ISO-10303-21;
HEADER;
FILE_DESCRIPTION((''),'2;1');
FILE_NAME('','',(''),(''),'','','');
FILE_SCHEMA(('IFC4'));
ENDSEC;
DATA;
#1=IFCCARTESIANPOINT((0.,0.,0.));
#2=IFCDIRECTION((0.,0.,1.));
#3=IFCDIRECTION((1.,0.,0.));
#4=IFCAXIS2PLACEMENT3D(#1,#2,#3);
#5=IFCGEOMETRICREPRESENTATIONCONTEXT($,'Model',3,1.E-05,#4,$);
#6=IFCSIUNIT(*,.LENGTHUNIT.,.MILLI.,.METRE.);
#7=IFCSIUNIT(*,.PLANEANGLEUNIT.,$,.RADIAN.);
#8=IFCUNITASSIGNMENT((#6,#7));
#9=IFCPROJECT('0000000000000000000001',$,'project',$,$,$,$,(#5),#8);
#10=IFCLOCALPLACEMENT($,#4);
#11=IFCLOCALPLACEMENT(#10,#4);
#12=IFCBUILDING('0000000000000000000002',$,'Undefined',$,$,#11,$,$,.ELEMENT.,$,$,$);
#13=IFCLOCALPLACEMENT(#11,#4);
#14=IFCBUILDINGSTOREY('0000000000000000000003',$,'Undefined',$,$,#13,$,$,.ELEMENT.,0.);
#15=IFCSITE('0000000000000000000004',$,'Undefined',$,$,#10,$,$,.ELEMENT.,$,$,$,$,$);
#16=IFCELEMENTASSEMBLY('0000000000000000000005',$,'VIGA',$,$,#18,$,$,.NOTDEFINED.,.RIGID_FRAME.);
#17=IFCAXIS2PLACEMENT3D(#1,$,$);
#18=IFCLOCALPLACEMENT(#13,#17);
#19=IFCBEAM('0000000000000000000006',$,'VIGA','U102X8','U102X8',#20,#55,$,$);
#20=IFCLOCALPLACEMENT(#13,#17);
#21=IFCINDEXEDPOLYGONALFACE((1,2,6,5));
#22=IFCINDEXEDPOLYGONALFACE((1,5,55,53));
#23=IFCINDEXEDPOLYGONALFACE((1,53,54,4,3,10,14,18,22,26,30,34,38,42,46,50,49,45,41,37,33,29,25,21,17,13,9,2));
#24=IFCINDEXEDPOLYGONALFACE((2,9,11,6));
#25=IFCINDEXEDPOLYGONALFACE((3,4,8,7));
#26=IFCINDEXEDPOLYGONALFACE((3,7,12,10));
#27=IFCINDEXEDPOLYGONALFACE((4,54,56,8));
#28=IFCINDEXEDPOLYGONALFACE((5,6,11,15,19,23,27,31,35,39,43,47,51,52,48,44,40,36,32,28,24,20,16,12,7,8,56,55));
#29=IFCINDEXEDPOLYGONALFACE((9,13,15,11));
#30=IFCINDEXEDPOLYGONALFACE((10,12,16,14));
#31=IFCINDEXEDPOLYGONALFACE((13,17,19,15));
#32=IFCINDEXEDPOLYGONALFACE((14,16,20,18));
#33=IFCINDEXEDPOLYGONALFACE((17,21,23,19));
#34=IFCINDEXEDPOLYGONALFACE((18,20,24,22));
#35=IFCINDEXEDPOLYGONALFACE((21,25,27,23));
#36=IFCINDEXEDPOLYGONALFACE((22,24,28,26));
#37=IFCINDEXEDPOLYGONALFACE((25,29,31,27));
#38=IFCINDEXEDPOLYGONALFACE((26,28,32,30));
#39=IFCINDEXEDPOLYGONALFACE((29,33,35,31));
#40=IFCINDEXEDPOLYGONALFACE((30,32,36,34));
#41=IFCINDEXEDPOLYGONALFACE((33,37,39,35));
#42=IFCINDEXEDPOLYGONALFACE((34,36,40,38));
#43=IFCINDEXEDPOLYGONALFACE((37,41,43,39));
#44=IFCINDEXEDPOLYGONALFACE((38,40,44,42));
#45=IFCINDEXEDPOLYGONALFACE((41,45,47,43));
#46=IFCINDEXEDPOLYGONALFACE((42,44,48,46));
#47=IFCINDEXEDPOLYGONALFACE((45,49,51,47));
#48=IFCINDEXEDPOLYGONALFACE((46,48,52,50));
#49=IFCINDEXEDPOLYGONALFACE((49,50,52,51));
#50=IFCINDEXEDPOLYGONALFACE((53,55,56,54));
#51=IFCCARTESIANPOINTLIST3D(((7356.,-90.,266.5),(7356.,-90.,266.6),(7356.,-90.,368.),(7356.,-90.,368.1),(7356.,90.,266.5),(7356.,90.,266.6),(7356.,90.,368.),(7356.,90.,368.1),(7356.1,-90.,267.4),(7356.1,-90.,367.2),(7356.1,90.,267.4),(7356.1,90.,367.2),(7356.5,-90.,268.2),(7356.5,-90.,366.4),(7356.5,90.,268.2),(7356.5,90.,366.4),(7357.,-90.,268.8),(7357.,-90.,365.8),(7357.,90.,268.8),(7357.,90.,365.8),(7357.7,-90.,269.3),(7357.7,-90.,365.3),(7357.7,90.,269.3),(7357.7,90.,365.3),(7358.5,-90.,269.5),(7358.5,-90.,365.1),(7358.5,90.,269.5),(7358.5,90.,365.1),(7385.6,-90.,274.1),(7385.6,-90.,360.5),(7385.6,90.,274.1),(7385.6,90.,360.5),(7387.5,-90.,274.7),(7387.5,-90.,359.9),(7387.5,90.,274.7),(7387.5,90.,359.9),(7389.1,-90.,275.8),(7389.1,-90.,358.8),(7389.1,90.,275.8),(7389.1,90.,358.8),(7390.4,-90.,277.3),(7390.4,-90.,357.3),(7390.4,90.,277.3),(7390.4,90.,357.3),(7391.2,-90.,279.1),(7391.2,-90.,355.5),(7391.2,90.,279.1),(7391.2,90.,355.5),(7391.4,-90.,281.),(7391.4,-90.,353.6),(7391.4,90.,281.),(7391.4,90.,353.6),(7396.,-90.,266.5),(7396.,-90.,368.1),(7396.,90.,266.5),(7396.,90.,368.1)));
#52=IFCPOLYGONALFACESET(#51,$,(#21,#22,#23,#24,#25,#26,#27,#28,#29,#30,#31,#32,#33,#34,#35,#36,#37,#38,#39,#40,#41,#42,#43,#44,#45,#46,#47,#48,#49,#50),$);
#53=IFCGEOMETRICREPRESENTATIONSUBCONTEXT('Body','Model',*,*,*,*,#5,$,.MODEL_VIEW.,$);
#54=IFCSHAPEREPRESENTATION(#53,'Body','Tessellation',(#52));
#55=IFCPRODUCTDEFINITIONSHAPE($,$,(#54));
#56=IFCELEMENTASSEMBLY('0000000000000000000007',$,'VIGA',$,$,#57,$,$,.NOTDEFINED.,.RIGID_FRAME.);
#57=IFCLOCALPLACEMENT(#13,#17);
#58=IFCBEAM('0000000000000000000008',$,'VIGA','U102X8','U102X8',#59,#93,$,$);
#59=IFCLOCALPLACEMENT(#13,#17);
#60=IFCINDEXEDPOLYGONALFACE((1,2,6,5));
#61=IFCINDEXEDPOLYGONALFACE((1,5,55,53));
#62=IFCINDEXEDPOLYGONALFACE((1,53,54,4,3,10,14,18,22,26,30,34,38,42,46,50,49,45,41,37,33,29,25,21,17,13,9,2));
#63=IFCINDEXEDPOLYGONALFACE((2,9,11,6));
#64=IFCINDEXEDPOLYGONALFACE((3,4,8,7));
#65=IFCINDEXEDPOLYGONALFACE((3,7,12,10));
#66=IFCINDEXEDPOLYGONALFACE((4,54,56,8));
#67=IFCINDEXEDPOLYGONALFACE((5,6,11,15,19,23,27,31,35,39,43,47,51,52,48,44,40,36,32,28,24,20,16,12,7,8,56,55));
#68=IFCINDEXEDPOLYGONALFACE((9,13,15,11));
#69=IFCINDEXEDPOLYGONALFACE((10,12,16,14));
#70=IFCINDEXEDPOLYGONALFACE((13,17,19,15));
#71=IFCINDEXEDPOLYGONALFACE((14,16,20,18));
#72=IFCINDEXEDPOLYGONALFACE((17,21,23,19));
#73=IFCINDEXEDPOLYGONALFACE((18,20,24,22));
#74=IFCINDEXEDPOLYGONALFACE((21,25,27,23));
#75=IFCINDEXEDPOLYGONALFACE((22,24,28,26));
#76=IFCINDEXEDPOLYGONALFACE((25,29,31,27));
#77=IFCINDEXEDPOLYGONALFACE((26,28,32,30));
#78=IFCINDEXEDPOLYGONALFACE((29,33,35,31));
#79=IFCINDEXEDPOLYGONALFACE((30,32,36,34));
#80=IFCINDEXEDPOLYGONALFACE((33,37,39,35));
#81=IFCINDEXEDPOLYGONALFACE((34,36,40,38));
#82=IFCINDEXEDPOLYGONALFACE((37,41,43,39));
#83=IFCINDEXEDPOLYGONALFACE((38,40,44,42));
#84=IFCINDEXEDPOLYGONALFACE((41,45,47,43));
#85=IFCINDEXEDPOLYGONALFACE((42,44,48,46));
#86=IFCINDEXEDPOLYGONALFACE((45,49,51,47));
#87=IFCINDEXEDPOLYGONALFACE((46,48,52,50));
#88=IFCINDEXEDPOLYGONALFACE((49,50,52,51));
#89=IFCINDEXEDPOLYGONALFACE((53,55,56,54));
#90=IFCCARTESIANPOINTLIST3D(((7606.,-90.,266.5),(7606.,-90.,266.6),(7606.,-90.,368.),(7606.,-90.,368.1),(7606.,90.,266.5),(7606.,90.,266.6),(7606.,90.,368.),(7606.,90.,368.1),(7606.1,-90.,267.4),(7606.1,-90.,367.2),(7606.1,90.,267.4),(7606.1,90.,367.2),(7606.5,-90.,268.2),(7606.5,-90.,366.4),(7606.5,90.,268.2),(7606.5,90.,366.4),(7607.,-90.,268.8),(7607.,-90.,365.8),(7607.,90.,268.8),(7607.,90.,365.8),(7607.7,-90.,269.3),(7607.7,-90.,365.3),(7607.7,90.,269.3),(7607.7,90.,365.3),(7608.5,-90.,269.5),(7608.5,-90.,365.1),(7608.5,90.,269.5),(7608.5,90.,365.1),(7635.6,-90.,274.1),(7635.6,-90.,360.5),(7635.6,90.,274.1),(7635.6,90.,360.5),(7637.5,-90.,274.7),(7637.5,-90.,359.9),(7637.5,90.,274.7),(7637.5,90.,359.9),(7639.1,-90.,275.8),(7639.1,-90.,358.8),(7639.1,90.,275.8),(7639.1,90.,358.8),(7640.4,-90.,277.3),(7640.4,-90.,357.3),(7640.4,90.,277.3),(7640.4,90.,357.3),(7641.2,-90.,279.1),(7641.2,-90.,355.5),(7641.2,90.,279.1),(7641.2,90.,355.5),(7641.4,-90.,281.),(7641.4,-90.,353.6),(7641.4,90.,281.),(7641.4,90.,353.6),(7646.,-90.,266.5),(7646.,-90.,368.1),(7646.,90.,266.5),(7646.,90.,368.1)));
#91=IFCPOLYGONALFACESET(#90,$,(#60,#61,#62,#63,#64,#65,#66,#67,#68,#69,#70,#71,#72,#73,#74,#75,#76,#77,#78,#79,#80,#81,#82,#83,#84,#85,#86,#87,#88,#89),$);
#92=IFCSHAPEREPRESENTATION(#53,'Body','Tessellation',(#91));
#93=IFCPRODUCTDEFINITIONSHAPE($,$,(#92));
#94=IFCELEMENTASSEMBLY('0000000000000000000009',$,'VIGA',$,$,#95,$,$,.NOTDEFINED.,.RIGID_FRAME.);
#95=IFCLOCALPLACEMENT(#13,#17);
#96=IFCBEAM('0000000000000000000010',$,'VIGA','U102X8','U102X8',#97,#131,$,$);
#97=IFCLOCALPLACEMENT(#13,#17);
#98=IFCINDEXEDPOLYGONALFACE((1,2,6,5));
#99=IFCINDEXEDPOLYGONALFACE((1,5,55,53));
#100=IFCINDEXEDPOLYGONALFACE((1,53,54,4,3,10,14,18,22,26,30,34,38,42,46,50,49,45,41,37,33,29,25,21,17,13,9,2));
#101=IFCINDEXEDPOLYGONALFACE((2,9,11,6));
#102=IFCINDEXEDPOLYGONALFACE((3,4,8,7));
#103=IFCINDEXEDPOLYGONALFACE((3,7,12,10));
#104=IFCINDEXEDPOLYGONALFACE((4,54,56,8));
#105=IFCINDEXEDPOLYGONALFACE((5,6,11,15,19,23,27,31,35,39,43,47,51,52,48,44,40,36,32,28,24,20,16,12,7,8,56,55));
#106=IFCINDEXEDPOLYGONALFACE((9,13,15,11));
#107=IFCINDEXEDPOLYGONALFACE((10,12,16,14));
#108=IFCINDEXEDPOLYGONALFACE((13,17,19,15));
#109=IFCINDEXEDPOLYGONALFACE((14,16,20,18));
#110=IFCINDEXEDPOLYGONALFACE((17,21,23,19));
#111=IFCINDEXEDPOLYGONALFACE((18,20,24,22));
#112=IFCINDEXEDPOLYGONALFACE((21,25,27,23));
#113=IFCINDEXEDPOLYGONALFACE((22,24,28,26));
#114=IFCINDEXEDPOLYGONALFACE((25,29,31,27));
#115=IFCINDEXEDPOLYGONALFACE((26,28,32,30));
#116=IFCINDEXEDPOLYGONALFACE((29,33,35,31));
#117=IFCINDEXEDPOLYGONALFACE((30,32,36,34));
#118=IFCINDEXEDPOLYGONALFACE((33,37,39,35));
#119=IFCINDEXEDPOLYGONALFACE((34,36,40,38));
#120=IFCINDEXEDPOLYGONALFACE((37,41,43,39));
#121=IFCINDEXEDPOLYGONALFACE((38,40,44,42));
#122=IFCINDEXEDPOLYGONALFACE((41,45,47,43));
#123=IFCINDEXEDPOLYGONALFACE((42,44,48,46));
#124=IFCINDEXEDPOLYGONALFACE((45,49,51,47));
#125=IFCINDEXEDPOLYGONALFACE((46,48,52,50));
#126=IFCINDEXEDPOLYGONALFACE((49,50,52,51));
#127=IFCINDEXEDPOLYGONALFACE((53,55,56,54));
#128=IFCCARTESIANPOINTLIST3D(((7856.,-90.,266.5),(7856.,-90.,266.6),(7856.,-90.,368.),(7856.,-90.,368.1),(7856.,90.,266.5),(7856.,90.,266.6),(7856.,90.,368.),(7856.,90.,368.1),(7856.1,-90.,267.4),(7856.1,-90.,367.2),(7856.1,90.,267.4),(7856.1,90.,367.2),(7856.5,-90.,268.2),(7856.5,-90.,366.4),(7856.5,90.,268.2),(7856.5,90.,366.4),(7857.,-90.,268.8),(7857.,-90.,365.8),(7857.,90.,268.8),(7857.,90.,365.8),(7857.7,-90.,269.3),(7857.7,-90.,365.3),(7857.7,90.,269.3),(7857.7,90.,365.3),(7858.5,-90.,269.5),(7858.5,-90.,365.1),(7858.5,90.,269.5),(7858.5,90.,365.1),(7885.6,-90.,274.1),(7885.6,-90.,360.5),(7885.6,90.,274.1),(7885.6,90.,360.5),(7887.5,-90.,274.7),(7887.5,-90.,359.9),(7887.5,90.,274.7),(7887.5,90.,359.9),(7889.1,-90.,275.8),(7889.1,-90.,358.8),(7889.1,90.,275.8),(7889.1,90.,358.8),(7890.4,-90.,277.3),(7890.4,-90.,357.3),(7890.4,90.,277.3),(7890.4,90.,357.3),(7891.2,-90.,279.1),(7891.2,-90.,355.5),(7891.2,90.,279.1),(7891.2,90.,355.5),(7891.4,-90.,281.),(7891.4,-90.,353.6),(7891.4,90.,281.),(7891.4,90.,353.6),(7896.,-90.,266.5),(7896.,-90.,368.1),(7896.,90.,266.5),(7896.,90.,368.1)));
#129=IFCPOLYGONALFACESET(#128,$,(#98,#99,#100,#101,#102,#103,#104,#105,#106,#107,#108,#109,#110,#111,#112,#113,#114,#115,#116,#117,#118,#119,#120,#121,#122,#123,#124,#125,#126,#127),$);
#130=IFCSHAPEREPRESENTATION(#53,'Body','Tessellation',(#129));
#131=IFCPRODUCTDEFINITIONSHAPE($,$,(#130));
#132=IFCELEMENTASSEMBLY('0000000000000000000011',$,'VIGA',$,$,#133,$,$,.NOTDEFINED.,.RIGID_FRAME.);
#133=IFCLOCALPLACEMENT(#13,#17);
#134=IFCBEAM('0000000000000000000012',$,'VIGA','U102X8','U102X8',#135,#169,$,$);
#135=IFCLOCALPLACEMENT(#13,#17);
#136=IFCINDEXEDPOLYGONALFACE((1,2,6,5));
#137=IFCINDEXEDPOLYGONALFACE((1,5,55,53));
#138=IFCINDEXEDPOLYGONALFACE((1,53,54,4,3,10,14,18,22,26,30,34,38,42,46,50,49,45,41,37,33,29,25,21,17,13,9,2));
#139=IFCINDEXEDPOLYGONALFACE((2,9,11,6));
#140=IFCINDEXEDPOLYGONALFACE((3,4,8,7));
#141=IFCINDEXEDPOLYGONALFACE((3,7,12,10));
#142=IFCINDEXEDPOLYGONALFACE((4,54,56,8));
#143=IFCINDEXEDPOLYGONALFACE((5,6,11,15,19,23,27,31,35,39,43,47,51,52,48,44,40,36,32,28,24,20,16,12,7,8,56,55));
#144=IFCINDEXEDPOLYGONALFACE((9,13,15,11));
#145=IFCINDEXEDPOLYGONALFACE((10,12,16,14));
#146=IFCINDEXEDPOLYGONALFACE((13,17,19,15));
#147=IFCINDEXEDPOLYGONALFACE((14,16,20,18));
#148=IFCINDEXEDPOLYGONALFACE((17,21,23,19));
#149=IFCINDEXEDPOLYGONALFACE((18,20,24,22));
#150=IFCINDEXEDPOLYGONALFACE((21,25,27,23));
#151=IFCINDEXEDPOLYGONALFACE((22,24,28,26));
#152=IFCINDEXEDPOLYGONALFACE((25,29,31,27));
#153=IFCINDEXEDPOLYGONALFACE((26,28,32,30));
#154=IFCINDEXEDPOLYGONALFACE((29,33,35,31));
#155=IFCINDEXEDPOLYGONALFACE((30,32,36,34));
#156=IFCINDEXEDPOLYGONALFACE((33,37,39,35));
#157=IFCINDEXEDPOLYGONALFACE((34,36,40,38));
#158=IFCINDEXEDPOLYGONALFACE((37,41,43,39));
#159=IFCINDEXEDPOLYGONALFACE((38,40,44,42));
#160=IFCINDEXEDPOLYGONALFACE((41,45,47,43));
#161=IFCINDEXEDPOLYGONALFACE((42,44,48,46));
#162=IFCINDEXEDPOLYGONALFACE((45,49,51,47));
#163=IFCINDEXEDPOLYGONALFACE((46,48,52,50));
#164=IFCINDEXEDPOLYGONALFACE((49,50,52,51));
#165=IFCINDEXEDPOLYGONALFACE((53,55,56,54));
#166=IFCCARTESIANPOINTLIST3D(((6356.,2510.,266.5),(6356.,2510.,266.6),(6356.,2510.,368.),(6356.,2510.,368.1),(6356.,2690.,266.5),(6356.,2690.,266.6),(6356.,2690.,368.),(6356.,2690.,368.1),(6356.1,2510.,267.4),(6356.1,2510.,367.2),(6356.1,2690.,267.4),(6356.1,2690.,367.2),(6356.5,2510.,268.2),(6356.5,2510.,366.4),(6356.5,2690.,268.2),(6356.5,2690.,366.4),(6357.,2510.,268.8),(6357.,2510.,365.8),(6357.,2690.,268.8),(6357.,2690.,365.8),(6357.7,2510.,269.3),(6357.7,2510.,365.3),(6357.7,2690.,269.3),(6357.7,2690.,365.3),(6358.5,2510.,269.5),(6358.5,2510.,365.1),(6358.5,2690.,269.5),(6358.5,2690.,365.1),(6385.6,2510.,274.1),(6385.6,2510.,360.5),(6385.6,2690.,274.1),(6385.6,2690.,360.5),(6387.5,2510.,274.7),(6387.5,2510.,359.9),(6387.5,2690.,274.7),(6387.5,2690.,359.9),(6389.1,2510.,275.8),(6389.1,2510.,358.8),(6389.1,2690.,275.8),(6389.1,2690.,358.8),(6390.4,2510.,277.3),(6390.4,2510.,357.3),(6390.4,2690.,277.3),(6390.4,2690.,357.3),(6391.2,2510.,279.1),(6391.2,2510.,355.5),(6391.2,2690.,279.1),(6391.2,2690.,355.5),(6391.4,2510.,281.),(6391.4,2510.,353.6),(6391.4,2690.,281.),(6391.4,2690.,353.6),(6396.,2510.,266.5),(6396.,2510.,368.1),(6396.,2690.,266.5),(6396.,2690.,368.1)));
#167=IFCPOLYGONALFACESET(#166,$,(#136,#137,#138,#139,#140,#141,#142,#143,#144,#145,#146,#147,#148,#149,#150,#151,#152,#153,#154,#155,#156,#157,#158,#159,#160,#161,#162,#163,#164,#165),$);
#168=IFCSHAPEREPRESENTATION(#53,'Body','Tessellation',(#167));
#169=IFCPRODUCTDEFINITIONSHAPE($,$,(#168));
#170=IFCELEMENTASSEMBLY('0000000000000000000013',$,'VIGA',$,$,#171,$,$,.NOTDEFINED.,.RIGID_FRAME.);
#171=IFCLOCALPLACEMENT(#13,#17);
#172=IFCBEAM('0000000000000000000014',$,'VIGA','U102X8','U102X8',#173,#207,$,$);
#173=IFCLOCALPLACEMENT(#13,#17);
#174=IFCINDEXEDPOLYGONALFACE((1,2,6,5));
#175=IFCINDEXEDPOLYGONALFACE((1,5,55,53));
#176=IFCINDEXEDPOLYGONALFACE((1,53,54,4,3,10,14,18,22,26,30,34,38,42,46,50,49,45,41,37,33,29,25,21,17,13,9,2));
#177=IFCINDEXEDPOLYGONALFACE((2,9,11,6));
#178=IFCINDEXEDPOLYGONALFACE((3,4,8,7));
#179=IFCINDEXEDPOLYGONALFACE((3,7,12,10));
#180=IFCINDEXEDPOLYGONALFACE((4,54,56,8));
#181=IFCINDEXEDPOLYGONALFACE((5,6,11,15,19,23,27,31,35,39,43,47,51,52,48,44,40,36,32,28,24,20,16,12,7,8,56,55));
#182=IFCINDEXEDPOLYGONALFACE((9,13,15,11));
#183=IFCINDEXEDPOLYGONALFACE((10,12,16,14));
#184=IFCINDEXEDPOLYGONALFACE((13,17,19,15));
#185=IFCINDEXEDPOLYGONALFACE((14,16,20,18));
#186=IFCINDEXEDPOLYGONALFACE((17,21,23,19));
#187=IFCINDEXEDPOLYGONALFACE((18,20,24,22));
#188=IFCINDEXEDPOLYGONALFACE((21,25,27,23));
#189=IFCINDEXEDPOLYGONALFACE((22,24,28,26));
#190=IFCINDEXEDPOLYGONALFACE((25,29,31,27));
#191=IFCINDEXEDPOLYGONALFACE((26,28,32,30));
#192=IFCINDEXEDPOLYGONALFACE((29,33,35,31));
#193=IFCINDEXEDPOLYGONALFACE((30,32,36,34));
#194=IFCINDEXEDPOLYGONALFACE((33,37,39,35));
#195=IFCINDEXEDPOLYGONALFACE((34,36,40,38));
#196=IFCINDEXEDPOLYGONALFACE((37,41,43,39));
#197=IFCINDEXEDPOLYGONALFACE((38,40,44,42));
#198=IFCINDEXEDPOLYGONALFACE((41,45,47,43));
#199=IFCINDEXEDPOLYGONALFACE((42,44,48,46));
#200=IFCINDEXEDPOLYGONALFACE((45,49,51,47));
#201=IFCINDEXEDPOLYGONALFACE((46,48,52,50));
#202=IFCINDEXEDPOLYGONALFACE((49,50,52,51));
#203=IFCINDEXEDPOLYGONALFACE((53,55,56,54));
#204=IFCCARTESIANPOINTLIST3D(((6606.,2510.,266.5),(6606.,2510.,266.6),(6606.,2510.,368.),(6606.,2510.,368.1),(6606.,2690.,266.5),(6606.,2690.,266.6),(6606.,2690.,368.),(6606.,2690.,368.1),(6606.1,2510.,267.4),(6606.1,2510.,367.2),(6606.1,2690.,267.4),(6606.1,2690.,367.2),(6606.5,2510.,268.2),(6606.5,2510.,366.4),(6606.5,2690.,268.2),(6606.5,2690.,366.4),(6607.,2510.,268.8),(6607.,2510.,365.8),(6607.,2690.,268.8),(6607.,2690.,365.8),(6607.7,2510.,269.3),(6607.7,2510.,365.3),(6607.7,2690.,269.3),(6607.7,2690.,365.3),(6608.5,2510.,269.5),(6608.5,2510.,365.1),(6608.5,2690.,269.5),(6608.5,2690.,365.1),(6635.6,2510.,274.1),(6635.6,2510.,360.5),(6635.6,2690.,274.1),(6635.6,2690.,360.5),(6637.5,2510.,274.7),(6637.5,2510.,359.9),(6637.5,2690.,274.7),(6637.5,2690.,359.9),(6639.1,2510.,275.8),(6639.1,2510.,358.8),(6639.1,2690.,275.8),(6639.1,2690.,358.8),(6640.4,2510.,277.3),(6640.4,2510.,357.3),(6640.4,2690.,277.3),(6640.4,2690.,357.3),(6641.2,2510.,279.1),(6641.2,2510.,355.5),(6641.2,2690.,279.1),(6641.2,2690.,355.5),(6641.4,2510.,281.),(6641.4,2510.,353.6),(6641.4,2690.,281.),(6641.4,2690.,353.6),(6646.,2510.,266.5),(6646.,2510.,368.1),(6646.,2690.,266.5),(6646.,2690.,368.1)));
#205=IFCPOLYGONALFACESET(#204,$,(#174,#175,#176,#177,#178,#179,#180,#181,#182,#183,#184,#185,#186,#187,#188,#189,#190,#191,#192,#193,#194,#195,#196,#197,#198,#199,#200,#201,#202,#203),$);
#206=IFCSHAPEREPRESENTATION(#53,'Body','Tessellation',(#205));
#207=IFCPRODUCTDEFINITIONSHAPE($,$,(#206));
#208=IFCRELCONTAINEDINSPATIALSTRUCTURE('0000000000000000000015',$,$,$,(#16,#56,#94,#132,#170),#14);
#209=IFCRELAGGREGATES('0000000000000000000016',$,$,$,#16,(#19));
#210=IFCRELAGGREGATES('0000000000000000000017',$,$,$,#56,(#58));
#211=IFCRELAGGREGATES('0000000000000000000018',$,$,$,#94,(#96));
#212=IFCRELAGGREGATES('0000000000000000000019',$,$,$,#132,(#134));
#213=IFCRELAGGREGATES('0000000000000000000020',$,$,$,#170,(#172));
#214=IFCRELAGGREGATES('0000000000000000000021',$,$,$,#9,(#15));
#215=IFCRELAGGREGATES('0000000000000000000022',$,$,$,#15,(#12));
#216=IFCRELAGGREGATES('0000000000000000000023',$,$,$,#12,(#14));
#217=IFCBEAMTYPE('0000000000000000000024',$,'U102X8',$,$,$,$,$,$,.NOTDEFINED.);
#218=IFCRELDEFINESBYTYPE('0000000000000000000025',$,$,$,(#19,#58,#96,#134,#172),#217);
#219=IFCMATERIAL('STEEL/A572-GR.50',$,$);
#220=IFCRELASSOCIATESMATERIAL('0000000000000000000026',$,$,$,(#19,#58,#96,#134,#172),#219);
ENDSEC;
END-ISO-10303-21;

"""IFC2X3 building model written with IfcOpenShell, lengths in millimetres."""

from ifc_helpers import new_model, si_unit, frame, origin_with_axes, origin_2d_with_axis, place, context, subcontext, project, spatial, u_section, extrude, material, type_object, element, aggregate, save


model = new_model("IFC2X3")

# Units and contexts
model_context = context("Model", 3, precision=1e-05, world=origin_with_axes())
body_context = subcontext(model_context, "Body", "Model", "MODEL_VIEW")
ifc_project = project(units=[si_unit("LENGTHUNIT", "METRE", prefix="MILLI"), si_unit("PLANEANGLEUNIT", "RADIAN")], contexts=[model_context])

# Site, building, storey
site_placement = place(None, origin_with_axes())
site = spatial("IfcSite", under=ifc_project, at=site_placement, Name="Undefined", CompositionType="ELEMENT")
building_placement = place(site_placement, origin_with_axes())
building = spatial("IfcBuilding", under=site, at=building_placement, Name="Undefined", CompositionType="ELEMENT")
storey_placement = place(building_placement, origin_with_axes())
storey = spatial("IfcBuildingStorey", under=building, at=storey_placement, Name="Undefined", CompositionType="ELEMENT", Elevation=0.0)

# Element assemblies, beams
ifc_material_1 = material(Name="STEEL/A572-GR.50")
beam_type_1 = type_object("IfcBeamType", Name="U102X8", PredefinedType="NOTDEFINED")
assembly_1_placement = place(storey_placement, origin_with_axes())
assembly_1 = element("IfcElementAssembly", 1, at=assembly_1_placement, inside=storey, Name="VIGA", AssemblyPlace="NOTDEFINED", PredefinedType="RIGID_FRAME")
beam_1_placement = place(assembly_1_placement, frame((7376.0, 90.0, 317.3), z_axis=(0.0, 0.0, 1.0), x_axis=(0.0, -1.0, 0.0)))
beam_1 = element("IfcBeam", 2, at=beam_1_placement, type_object=beam_type_1, material=ifc_material_1, Name="VIGA", Description="U102X8", ObjectType="U102X8", context=body_context, shape_type="SweptSolid", body=[
    extrude(u_section(Depth=101.6, FlangeWidth=40.0, WebThickness=4.6, FlangeThickness=6.0, FilletRadius=7.0, EdgeRadius=3.0, FlangeSlope=0.16839, at=origin_2d_with_axis()), frame((180.0, 0.0, 0.0), z_axis=(-1.0, 0.0, 0.0), x_axis=(0.0, -1.0, 0.0)), (0.0, 0.0, 1.0), 180.0),
])
aggregate(assembly_1, [beam_1])
assembly_2_placement = place(storey_placement, origin_with_axes())
assembly_2 = element("IfcElementAssembly", 3, at=assembly_2_placement, inside=storey, Name="VIGA", AssemblyPlace="NOTDEFINED", PredefinedType="RIGID_FRAME")
beam_2_placement = place(assembly_2_placement, frame((7626.0, 90.0, 317.3), z_axis=(0.0, 0.0, 1.0), x_axis=(0.0, -1.0, 0.0)))
beam_2 = element("IfcBeam", 4, at=beam_2_placement, type_object=beam_type_1, material=ifc_material_1, Name="VIGA", Description="U102X8", ObjectType="U102X8", context=body_context, shape_type="SweptSolid", body=[
    extrude(u_section(Depth=101.6, FlangeWidth=40.0, WebThickness=4.6, FlangeThickness=6.0, FilletRadius=7.0, EdgeRadius=3.0, FlangeSlope=0.16839, at=origin_2d_with_axis()), frame((180.0, 0.0, 0.0), z_axis=(-1.0, 0.0, 0.0), x_axis=(0.0, -1.0, 0.0)), (0.0, 0.0, 1.0), 180.0),
])
aggregate(assembly_2, [beam_2])
assembly_3_placement = place(storey_placement, origin_with_axes())
assembly_3 = element("IfcElementAssembly", 5, at=assembly_3_placement, inside=storey, Name="VIGA", AssemblyPlace="NOTDEFINED", PredefinedType="RIGID_FRAME")
beam_3_placement = place(assembly_3_placement, frame((7876.0, 90.0, 317.3), z_axis=(0.0, 0.0, 1.0), x_axis=(0.0, -1.0, 0.0)))
beam_3 = element("IfcBeam", 6, at=beam_3_placement, type_object=beam_type_1, material=ifc_material_1, Name="VIGA", Description="U102X8", ObjectType="U102X8", context=body_context, shape_type="SweptSolid", body=[
    extrude(u_section(Depth=101.6, FlangeWidth=40.0, WebThickness=4.6, FlangeThickness=6.0, FilletRadius=7.0, EdgeRadius=3.0, FlangeSlope=0.16839, at=origin_2d_with_axis()), frame((180.0, 0.0, 0.0), z_axis=(-1.0, 0.0, 0.0), x_axis=(0.0, -1.0, 0.0)), (0.0, 0.0, 1.0), 180.0),
])
aggregate(assembly_3, [beam_3])
assembly_4_placement = place(storey_placement, origin_with_axes())
assembly_4 = element("IfcElementAssembly", 7, at=assembly_4_placement, inside=storey, Name="VIGA", AssemblyPlace="NOTDEFINED", PredefinedType="RIGID_FRAME")
beam_4_placement = place(assembly_4_placement, frame((6376.0, 2690.0, 317.3), z_axis=(0.0, 0.0, 1.0), x_axis=(0.0, -1.0, 0.0)))
beam_4 = element("IfcBeam", 8, at=beam_4_placement, type_object=beam_type_1, material=ifc_material_1, Name="VIGA", Description="U102X8", ObjectType="U102X8", context=body_context, shape_type="SweptSolid", body=[
    extrude(u_section(Depth=101.6, FlangeWidth=40.0, WebThickness=4.6, FlangeThickness=6.0, FilletRadius=7.0, EdgeRadius=3.0, FlangeSlope=0.16839, at=origin_2d_with_axis()), frame((180.0, 0.0, 0.0), z_axis=(-1.0, 0.0, 0.0), x_axis=(0.0, -1.0, 0.0)), (0.0, 0.0, 1.0), 180.0),
])
aggregate(assembly_4, [beam_4])
assembly_5_placement = place(storey_placement, origin_with_axes())
assembly_5 = element("IfcElementAssembly", 9, at=assembly_5_placement, inside=storey, Name="VIGA", AssemblyPlace="NOTDEFINED", PredefinedType="RIGID_FRAME")
beam_5_placement = place(assembly_5_placement, frame((6626.0, 2690.0, 317.3), z_axis=(0.0, 0.0, 1.0), x_axis=(0.0, -1.0, 0.0)))
beam_5 = element("IfcBeam", 10, at=beam_5_placement, type_object=beam_type_1, material=ifc_material_1, Name="VIGA", Description="U102X8", ObjectType="U102X8", context=body_context, shape_type="SweptSolid", body=[
    extrude(u_section(Depth=101.6, FlangeWidth=40.0, WebThickness=4.6, FlangeThickness=6.0, FilletRadius=7.0, EdgeRadius=3.0, FlangeSlope=0.16839, at=origin_2d_with_axis()), frame((180.0, 0.0, 0.0), z_axis=(-1.0, 0.0, 0.0), x_axis=(0.0, -1.0, 0.0)), (0.0, 0.0, 1.0), 180.0),
])
aggregate(assembly_5, [beam_5])

save(model, "model.ifc")
